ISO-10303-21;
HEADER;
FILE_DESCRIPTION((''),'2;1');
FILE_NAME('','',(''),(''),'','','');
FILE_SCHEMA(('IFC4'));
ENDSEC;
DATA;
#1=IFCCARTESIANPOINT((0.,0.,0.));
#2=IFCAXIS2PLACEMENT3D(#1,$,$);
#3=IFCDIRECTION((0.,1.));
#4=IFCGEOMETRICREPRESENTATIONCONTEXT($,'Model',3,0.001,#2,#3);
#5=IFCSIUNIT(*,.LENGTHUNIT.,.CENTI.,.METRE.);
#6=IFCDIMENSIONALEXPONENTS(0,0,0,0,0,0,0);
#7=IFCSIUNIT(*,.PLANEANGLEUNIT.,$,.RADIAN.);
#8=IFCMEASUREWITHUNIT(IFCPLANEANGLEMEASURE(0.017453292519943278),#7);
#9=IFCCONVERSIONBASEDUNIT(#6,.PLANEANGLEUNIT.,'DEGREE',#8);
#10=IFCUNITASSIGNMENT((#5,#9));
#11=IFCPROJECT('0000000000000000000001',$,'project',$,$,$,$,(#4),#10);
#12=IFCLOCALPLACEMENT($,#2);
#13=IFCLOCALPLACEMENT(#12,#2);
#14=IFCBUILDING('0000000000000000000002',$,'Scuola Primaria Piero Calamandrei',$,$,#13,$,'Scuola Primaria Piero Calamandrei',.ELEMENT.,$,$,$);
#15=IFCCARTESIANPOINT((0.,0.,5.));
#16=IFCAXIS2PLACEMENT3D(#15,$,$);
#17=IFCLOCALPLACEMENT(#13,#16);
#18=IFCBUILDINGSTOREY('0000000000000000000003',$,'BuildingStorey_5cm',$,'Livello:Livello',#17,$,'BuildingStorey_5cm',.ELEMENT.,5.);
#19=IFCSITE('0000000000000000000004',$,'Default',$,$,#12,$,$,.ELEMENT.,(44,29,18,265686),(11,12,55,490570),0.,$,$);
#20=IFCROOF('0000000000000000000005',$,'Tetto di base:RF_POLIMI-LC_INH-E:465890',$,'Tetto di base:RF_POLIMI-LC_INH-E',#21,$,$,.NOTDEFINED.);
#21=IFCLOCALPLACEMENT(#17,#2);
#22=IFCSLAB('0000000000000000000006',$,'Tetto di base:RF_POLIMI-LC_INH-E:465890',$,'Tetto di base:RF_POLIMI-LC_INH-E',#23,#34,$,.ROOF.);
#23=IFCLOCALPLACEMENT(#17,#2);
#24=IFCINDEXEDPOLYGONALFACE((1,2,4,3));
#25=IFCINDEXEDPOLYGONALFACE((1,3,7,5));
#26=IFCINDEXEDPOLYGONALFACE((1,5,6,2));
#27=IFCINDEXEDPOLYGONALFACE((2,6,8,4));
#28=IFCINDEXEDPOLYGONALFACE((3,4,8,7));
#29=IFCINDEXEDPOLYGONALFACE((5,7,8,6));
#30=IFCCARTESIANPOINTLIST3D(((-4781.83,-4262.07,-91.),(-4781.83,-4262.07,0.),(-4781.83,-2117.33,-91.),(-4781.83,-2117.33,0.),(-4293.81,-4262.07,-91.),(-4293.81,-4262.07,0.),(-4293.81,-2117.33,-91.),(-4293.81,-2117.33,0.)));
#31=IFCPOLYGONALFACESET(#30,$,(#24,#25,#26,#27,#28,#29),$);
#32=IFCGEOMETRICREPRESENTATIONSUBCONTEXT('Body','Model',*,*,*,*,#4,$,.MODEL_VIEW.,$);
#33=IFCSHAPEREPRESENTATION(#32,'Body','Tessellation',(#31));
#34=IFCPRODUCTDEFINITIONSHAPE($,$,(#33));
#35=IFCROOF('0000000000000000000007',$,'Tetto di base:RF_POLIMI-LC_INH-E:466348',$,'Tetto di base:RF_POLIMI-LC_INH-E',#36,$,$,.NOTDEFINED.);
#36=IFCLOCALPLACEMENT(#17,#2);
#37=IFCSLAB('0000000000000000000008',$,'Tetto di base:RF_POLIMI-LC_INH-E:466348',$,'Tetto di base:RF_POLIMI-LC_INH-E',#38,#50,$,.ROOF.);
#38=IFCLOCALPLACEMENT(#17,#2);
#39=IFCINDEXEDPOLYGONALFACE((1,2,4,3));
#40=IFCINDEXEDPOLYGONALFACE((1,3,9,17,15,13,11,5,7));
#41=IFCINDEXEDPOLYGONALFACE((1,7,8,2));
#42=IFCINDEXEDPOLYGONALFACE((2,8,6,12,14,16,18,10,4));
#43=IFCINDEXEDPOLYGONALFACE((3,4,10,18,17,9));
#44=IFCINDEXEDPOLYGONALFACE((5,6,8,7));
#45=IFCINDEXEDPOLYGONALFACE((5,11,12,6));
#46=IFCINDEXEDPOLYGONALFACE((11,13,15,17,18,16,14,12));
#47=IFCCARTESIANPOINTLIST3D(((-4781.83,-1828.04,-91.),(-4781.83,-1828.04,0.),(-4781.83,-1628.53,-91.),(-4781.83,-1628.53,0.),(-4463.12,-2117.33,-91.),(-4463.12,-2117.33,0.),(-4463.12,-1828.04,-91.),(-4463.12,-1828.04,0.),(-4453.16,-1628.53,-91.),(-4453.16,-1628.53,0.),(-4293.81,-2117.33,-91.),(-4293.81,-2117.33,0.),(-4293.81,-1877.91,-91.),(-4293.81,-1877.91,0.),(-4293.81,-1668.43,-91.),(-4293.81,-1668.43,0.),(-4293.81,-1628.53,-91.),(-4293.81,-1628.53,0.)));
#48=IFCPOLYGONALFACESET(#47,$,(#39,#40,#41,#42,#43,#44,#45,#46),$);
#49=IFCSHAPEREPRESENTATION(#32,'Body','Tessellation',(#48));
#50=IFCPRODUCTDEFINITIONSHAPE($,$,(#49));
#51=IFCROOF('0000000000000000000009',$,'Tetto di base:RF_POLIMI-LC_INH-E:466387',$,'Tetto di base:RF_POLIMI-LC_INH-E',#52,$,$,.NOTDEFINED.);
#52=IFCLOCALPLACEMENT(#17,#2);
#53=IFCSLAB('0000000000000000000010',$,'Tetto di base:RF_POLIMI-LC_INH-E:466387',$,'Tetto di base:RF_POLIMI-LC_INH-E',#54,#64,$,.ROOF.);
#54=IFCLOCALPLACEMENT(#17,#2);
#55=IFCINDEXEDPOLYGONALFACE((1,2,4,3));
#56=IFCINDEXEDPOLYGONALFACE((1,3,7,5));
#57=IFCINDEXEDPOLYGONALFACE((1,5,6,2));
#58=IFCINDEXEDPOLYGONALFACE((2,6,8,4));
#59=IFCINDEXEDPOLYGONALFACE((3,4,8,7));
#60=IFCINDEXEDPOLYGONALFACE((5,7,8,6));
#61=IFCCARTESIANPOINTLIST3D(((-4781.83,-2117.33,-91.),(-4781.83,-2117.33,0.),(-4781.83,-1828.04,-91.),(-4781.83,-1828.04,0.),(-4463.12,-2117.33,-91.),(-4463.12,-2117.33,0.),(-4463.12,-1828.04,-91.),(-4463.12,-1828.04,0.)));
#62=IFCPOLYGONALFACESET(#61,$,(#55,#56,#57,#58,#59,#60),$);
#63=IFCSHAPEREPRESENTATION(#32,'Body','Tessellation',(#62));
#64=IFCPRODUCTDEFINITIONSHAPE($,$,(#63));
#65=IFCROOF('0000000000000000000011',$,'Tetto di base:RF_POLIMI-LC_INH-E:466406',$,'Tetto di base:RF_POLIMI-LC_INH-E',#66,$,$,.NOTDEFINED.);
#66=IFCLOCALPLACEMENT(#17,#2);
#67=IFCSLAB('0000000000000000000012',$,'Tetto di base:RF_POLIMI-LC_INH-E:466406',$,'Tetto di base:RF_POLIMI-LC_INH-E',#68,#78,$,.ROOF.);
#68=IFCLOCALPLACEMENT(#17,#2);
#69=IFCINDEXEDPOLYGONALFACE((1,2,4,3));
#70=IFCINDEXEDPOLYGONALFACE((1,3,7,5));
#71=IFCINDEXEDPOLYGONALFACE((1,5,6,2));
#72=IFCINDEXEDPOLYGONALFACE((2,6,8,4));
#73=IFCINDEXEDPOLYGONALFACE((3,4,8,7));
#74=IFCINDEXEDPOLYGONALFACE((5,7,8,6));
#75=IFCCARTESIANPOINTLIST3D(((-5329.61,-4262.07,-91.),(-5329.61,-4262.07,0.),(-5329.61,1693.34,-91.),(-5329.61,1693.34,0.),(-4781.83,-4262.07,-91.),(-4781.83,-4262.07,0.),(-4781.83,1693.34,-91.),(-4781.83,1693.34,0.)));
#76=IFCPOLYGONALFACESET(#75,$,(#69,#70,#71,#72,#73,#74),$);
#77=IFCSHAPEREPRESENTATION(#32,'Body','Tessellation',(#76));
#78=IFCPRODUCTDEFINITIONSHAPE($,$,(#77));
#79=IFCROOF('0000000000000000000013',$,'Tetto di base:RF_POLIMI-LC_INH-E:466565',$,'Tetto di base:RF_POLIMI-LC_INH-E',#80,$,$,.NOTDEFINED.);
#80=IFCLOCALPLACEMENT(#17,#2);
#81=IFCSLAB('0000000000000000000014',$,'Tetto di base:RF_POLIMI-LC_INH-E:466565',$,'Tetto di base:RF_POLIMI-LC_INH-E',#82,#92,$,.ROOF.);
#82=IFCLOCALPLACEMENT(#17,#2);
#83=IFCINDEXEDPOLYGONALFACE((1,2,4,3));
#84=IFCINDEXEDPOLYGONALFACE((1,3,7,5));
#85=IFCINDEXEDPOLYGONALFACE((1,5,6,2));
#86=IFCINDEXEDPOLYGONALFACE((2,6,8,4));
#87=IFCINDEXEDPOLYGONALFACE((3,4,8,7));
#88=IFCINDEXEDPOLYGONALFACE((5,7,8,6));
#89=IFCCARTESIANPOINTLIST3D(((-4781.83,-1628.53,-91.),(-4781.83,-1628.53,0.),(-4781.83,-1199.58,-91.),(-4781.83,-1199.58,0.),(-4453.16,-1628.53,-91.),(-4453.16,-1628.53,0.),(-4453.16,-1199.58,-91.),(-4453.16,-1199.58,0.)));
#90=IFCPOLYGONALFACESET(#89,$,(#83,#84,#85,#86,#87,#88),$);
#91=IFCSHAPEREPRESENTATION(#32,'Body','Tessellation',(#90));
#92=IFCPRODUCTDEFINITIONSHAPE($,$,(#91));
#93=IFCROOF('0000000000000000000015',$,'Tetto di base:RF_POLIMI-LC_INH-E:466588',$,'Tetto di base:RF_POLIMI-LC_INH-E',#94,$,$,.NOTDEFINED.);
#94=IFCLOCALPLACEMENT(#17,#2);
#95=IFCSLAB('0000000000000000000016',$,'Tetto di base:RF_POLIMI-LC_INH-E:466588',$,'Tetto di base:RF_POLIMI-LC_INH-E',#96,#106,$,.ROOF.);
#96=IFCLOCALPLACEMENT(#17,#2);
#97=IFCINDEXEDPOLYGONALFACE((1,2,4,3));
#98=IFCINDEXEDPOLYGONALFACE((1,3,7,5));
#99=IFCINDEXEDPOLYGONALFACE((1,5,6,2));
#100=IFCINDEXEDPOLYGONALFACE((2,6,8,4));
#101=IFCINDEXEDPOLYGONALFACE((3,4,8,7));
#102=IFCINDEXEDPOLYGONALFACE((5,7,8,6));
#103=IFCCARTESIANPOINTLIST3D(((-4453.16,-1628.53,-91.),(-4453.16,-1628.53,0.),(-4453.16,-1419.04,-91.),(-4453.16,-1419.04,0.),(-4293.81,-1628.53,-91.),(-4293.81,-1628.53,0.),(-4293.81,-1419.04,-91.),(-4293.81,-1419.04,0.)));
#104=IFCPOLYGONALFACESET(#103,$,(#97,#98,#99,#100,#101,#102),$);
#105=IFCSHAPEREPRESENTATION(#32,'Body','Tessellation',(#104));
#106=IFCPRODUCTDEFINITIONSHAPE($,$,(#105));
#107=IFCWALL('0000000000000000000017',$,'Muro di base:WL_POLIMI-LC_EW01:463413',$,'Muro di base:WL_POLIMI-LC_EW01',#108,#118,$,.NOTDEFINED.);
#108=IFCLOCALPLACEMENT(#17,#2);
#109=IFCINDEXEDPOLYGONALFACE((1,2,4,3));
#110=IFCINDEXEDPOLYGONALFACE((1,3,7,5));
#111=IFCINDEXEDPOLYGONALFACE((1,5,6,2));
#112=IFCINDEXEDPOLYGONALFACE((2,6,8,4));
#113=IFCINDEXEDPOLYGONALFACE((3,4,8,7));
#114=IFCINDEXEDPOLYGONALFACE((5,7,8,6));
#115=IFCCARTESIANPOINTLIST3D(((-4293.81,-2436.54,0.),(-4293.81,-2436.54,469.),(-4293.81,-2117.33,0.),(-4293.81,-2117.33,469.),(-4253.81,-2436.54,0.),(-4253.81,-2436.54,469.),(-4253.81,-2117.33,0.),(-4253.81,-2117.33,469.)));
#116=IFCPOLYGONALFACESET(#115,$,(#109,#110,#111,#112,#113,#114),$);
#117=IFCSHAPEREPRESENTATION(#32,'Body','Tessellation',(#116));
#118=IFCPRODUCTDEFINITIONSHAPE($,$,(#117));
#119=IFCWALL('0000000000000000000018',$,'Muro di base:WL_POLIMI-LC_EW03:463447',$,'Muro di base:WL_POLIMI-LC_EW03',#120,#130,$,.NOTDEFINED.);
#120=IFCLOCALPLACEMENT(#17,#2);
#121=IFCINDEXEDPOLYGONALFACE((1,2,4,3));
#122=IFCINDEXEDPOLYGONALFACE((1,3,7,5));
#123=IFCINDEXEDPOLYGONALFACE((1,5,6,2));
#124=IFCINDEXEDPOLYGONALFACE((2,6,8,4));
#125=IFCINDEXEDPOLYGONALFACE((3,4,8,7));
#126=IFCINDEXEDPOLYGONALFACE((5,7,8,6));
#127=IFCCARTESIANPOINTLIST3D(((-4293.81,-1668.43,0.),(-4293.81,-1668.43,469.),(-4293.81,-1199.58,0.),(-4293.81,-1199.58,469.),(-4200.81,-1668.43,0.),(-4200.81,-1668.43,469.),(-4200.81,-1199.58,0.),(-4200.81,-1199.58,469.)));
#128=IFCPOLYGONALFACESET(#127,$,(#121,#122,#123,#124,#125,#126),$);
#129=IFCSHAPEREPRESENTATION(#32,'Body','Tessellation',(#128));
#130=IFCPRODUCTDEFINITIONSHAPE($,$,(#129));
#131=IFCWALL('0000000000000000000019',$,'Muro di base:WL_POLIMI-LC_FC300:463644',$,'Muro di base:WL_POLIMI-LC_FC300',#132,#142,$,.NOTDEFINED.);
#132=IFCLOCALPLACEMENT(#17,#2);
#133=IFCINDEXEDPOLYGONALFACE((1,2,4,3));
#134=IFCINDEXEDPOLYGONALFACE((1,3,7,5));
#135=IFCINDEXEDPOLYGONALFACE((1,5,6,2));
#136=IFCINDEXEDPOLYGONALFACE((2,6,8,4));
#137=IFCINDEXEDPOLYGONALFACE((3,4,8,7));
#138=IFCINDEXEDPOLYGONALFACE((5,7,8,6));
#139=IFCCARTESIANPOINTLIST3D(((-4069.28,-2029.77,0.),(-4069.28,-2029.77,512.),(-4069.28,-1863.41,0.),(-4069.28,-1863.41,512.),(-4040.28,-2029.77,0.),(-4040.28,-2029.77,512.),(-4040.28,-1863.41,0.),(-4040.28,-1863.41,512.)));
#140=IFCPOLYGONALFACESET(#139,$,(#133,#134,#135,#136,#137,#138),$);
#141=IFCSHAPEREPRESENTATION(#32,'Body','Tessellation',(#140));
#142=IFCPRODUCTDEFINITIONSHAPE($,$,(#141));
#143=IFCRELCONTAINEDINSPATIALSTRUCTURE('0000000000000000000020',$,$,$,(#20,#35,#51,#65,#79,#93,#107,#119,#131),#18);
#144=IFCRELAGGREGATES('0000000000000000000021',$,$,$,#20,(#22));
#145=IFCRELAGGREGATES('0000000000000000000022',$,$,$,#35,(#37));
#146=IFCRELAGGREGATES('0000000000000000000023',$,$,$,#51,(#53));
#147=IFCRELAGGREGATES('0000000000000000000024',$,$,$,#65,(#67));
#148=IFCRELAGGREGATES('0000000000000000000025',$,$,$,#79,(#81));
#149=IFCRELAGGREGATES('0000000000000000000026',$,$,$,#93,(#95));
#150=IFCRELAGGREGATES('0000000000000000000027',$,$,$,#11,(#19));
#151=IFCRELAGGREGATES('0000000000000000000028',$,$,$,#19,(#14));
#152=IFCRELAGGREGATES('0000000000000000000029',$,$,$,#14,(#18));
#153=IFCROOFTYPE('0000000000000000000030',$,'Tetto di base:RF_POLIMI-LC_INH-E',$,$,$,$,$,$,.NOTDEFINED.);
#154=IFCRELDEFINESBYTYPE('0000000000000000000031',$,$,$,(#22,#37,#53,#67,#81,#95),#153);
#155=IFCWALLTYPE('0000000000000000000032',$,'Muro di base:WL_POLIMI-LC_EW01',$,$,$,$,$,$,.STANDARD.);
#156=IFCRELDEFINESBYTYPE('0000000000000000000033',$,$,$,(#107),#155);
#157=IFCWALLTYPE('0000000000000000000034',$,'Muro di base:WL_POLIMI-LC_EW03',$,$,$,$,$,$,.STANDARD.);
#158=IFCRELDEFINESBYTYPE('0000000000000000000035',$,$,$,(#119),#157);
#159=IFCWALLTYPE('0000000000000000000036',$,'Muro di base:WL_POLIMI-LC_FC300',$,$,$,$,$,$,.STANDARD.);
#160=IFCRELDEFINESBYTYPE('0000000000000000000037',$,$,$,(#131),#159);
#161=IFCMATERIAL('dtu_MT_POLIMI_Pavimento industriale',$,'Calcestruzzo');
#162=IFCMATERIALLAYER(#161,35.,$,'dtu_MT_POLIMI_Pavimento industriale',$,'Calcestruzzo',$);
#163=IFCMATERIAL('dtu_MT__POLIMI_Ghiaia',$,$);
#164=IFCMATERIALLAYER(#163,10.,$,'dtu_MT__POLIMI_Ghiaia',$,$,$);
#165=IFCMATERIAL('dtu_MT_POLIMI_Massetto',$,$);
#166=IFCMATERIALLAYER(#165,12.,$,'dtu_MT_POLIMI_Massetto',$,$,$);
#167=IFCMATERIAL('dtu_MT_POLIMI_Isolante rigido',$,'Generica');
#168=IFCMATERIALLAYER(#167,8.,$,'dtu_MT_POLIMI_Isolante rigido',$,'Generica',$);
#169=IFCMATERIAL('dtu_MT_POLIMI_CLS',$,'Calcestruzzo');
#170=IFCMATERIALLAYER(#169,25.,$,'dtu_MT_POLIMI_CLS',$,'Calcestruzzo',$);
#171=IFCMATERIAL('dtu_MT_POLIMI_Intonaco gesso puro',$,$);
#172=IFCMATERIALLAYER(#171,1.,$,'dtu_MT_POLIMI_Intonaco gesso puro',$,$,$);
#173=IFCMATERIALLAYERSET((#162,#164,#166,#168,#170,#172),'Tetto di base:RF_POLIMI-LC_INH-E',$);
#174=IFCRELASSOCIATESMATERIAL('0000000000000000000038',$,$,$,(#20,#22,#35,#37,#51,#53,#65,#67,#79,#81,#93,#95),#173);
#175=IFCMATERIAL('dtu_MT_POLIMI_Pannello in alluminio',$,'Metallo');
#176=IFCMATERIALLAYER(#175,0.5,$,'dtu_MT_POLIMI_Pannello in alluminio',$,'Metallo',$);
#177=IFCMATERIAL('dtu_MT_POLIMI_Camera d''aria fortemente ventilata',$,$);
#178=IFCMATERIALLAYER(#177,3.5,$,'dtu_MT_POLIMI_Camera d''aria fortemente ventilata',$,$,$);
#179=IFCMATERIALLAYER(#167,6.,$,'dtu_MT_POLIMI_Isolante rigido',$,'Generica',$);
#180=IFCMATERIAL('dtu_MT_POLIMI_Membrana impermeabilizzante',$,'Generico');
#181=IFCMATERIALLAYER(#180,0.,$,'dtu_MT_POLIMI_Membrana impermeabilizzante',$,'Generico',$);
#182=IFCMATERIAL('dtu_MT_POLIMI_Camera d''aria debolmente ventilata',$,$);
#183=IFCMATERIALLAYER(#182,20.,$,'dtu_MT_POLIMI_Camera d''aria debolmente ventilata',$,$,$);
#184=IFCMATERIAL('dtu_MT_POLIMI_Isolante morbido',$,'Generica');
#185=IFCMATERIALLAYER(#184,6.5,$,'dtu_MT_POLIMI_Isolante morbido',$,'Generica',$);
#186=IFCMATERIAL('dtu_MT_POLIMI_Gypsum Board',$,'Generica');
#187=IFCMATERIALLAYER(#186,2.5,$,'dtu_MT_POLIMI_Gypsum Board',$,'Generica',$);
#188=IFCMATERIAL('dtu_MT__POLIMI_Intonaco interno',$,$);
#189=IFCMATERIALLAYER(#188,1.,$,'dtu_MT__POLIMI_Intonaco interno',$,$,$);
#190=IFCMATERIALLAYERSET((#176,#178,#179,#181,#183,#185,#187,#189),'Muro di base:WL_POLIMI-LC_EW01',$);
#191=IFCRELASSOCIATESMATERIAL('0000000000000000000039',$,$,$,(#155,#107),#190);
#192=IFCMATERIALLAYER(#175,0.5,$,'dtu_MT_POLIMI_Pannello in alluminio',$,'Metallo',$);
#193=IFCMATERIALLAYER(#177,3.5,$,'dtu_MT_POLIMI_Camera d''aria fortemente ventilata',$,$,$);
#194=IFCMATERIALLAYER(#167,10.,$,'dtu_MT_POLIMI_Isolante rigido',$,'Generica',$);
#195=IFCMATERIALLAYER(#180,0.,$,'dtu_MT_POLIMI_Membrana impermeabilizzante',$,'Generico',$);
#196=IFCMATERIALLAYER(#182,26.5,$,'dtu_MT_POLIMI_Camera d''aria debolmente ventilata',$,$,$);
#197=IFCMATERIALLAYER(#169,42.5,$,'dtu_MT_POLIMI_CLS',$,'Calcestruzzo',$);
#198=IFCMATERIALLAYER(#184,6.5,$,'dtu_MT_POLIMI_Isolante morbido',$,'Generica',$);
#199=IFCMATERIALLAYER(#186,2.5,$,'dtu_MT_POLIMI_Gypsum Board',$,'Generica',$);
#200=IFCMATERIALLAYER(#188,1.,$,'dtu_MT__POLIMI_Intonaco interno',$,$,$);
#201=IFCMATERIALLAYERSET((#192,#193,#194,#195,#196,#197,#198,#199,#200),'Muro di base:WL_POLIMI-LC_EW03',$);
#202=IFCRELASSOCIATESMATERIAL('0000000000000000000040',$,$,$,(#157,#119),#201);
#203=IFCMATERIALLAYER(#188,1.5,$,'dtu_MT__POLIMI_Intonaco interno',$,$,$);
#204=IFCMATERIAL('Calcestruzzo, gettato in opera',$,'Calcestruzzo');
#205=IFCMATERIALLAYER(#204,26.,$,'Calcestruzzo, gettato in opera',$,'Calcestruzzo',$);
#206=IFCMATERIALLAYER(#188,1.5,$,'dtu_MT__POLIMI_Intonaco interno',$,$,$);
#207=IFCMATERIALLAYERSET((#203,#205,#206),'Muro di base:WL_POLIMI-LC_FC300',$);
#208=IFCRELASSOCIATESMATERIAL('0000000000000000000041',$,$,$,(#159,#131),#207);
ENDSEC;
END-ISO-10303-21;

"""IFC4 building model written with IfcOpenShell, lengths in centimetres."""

from ifc_helpers import new_model, entity, si_unit, converted_unit, direction, frame, frame_2d, origin, place, context, subcontext, project, spatial, polyline, rectangle, outline, extrude, clip, bounded_halfspace, material, layer, layer_set, layer_usage, type_object, element, aggregate, save


model = new_model("IFC4")

# Units and contexts
model_context = context("Model", 3, precision=0.001, world=origin(), true_north=direction((0.0, 1.0)))
body_context = subcontext(model_context, "Body", "Model", "MODEL_VIEW")
ifc_project = project(units=[si_unit("LENGTHUNIT", "METRE", prefix="CENTI"), converted_unit("PLANEANGLEUNIT", "DEGREE", entity("IfcPlaneAngleMeasure", 0.017453292519943278), si_unit("PLANEANGLEUNIT", "RADIAN"), dimensions=[0, 0, 0, 0, 0, 0, 0])], contexts=[model_context])

# Site, building, storey
site_placement = place(None, origin())
site = spatial("IfcSite", under=ifc_project, at=site_placement, Name="Default", CompositionType="ELEMENT", RefLatitude=(44, 29, 18, 265686), RefLongitude=(11, 12, 55, 490570), RefElevation=0.0)
building_placement = place(site_placement, origin())
building = spatial("IfcBuilding", under=site, at=building_placement, Name="Scuola Primaria Piero Calamandrei", LongName="Scuola Primaria Piero Calamandrei", CompositionType="ELEMENT")
storey_placement = place(building_placement, frame((0.0, 0.0, 5.0)))
storey = spatial("IfcBuildingStorey", under=building, at=storey_placement, Name="BuildingStorey_5cm", ObjectType="Livello:Livello", LongName="BuildingStorey_5cm", CompositionType="ELEMENT", Elevation=5.0)

# Roofs, slabs
ifc_material_1 = material(Name="dtu_MT_POLIMI_Pavimento industriale", Category="Calcestruzzo")
ifc_layer_1 = layer(ifc_material_1, 35.0, Name="dtu_MT_POLIMI_Pavimento industriale", Category="Calcestruzzo")
ifc_material_2 = material(Name="dtu_MT__POLIMI_Ghiaia")
ifc_layer_2 = layer(ifc_material_2, 10.0, Name="dtu_MT__POLIMI_Ghiaia")
ifc_material_3 = material(Name="dtu_MT_POLIMI_Massetto")
ifc_layer_3 = layer(ifc_material_3, 12.0, Name="dtu_MT_POLIMI_Massetto")
ifc_material_4 = material(Name="dtu_MT_POLIMI_Isolante rigido", Category="Generica")
ifc_layer_4 = layer(ifc_material_4, 8.0, Name="dtu_MT_POLIMI_Isolante rigido", Category="Generica")
ifc_material_5 = material(Name="dtu_MT_POLIMI_CLS", Category="Calcestruzzo")
ifc_layer_5 = layer(ifc_material_5, 25.0, Name="dtu_MT_POLIMI_CLS", Category="Calcestruzzo")
ifc_material_6 = material(Name="dtu_MT_POLIMI_Intonaco gesso puro")
ifc_layer_6 = layer(ifc_material_6, 1.0, Name="dtu_MT_POLIMI_Intonaco gesso puro")
ifc_layer_set_1 = layer_set([ifc_layer_1, ifc_layer_2, ifc_layer_3, ifc_layer_4, ifc_layer_5, ifc_layer_6], Name="Tetto di base:RF_POLIMI-LC_INH-E")
roof_1_placement = place(storey_placement, frame((-4781.83, -4262.07, -91.0)))
roof_1 = element("IfcRoof", 1, at=roof_1_placement, inside=storey, material=ifc_layer_set_1, Name="Tetto di base:RF_POLIMI-LC_INH-E:465890", ObjectType="Tetto di base:RF_POLIMI-LC_INH-E", PredefinedType="NOTDEFINED")
roof_type = type_object("IfcRoofType", Name="Tetto di base:RF_POLIMI-LC_INH-E", PredefinedType="NOTDEFINED")
slab_1_placement = place(roof_1_placement, origin())
slab_1 = element("IfcSlab", 2, at=slab_1_placement, type_object=roof_type, material=ifc_layer_set_1, Name="Tetto di base:RF_POLIMI-LC_INH-E:465890", ObjectType="Tetto di base:RF_POLIMI-LC_INH-E", PredefinedType="ROOF", context=body_context, shape_type="SweptSolid", body=[
    extrude(rectangle(XDim=488.02, YDim=2144.74, at=frame_2d((0.0, 0.0), x_axis=(1.0, 0.0))), frame((244.01, 1072.37, 0.0)), (0.0, 0.0, 1.0), 91.0),
])
aggregate(roof_1, [slab_1])
roof_2_placement = place(storey_placement, frame((-4781.83, -2117.33, -91.0)))
roof_2 = element("IfcRoof", 3, at=roof_2_placement, inside=storey, material=ifc_layer_set_1, Name="Tetto di base:RF_POLIMI-LC_INH-E:466348", ObjectType="Tetto di base:RF_POLIMI-LC_INH-E", PredefinedType="NOTDEFINED")
slab_2_placement = place(roof_2_placement, origin())
slab_2 = element("IfcSlab", 4, at=slab_2_placement, type_object=roof_type, material=ifc_layer_set_1, Name="Tetto di base:RF_POLIMI-LC_INH-E:466348", ObjectType="Tetto di base:RF_POLIMI-LC_INH-E", PredefinedType="ROOF", context=body_context, shape_type="SweptSolid", body=[
    extrude(outline(polyline([(244.01, 244.4), (84.66, 244.4), (-244.01, 244.4), (-244.01, 44.89), (74.7, 44.89), (74.7, -244.4), (244.01, -244.4), (244.01, -4.99), (244.01, 204.5), (244.01, 244.4)])), frame((244.01, 244.4, 0.0)), (0.0, 0.0, 1.0), 91.0),
])
aggregate(roof_2, [slab_2])
roof_3_placement = place(storey_placement, frame((-4781.83, -2117.33, -91.0)))
roof_3 = element("IfcRoof", 5, at=roof_3_placement, inside=storey, material=ifc_layer_set_1, Name="Tetto di base:RF_POLIMI-LC_INH-E:466387", ObjectType="Tetto di base:RF_POLIMI-LC_INH-E", PredefinedType="NOTDEFINED")
slab_3_placement = place(roof_3_placement, origin())
slab_3 = element("IfcSlab", 6, at=slab_3_placement, type_object=roof_type, material=ifc_layer_set_1, Name="Tetto di base:RF_POLIMI-LC_INH-E:466387", ObjectType="Tetto di base:RF_POLIMI-LC_INH-E", PredefinedType="ROOF", context=body_context, shape_type="SweptSolid", body=[
    extrude(rectangle(XDim=289.29, YDim=318.71, at=frame_2d((0.0, 0.0), x_axis=(0.0, -1.0))), frame((159.35, 144.65, 0.0)), (0.0, 0.0, 1.0), 91.0),
])
aggregate(roof_3, [slab_3])
roof_4_placement = place(storey_placement, frame((-5329.61, -4262.07, -91.0)))
roof_4 = element("IfcRoof", 7, at=roof_4_placement, inside=storey, material=ifc_layer_set_1, Name="Tetto di base:RF_POLIMI-LC_INH-E:466406", ObjectType="Tetto di base:RF_POLIMI-LC_INH-E", PredefinedType="NOTDEFINED")
slab_4_placement = place(roof_4_placement, origin())
slab_4 = element("IfcSlab", 8, at=slab_4_placement, type_object=roof_type, material=ifc_layer_set_1, Name="Tetto di base:RF_POLIMI-LC_INH-E:466406", ObjectType="Tetto di base:RF_POLIMI-LC_INH-E", PredefinedType="ROOF", context=body_context, shape_type="SweptSolid", body=[
    extrude(rectangle(XDim=5955.41, YDim=547.78, at=frame_2d((0.0, 0.0), x_axis=(0.0, -1.0))), frame((273.89, 2977.7, 0.0)), (0.0, 0.0, 1.0), 91.0),
])
aggregate(roof_4, [slab_4])
roof_5_placement = place(storey_placement, frame((-4781.83, -1628.53, -91.0)))
roof_5 = element("IfcRoof", 9, at=roof_5_placement, inside=storey, material=ifc_layer_set_1, Name="Tetto di base:RF_POLIMI-LC_INH-E:466565", ObjectType="Tetto di base:RF_POLIMI-LC_INH-E", PredefinedType="NOTDEFINED")
slab_5_placement = place(roof_5_placement, origin())
slab_5 = element("IfcSlab", 10, at=slab_5_placement, type_object=roof_type, material=ifc_layer_set_1, Name="Tetto di base:RF_POLIMI-LC_INH-E:466565", ObjectType="Tetto di base:RF_POLIMI-LC_INH-E", PredefinedType="ROOF", context=body_context, shape_type="SweptSolid", body=[
    extrude(rectangle(XDim=428.95, YDim=328.67, at=frame_2d((0.0, 0.0), x_axis=(0.0, -1.0))), frame((164.33, 214.47, 0.0)), (0.0, 0.0, 1.0), 91.0),
])
aggregate(roof_5, [slab_5])
roof_6_placement = place(storey_placement, frame((-4453.16, -1628.53, -91.0)))
roof_6 = element("IfcRoof", 11, at=roof_6_placement, inside=storey, material=ifc_layer_set_1, Name="Tetto di base:RF_POLIMI-LC_INH-E:466588", ObjectType="Tetto di base:RF_POLIMI-LC_INH-E", PredefinedType="NOTDEFINED")
slab_6_placement = place(roof_6_placement, origin())
slab_6 = element("IfcSlab", 12, at=slab_6_placement, type_object=roof_type, material=ifc_layer_set_1, Name="Tetto di base:RF_POLIMI-LC_INH-E:466588", ObjectType="Tetto di base:RF_POLIMI-LC_INH-E", PredefinedType="ROOF", context=body_context, shape_type="SweptSolid", body=[
    extrude(rectangle(XDim=159.35, YDim=209.49, at=frame_2d((0.0, 0.0), x_axis=(1.0, 0.0))), frame((79.68, 104.74, 0.0)), (0.0, 0.0, 1.0), 91.0),
])
aggregate(roof_6, [slab_6])

# Walls
ifc_material_7 = material(Name="dtu_MT_POLIMI_Pannello in alluminio", Category="Metallo")
ifc_layer_7 = layer(ifc_material_7, 0.5, Name="dtu_MT_POLIMI_Pannello in alluminio", Category="Metallo")
ifc_material_8 = material(Name="dtu_MT_POLIMI_Camera d'aria fortemente ventilata")
ifc_layer_8 = layer(ifc_material_8, 3.5, Name="dtu_MT_POLIMI_Camera d'aria fortemente ventilata")
ifc_layer_9 = layer(ifc_material_4, 6.0, Name="dtu_MT_POLIMI_Isolante rigido", Category="Generica")
ifc_material_9 = material(Name="dtu_MT_POLIMI_Membrana impermeabilizzante", Category="Generico")
ifc_layer_10 = layer(ifc_material_9, 0.0, Name="dtu_MT_POLIMI_Membrana impermeabilizzante", Category="Generico")
ifc_material_10 = material(Name="dtu_MT_POLIMI_Camera d'aria debolmente ventilata")
ifc_layer_11 = layer(ifc_material_10, 20.0, Name="dtu_MT_POLIMI_Camera d'aria debolmente ventilata")
ifc_material_11 = material(Name="dtu_MT_POLIMI_Isolante morbido", Category="Generica")
ifc_layer_12 = layer(ifc_material_11, 6.5, Name="dtu_MT_POLIMI_Isolante morbido", Category="Generica")
ifc_material_12 = material(Name="dtu_MT_POLIMI_Gypsum Board", Category="Generica")
ifc_layer_13 = layer(ifc_material_12, 2.5, Name="dtu_MT_POLIMI_Gypsum Board", Category="Generica")
ifc_material_13 = material(Name="dtu_MT__POLIMI_Intonaco interno")
ifc_layer_14 = layer(ifc_material_13, 1.0, Name="dtu_MT__POLIMI_Intonaco interno")
ifc_layer_set_2 = layer_set([ifc_layer_7, ifc_layer_8, ifc_layer_9, ifc_layer_10, ifc_layer_11, ifc_layer_12, ifc_layer_13, ifc_layer_14], Name="Muro di base:WL_POLIMI-LC_EW01")
ifc_layer_usage_1 = layer_usage(ifc_layer_set_2, "AXIS2", "NEGATIVE", 20.0)
wall_type_1 = type_object("IfcWallType", Name="Muro di base:WL_POLIMI-LC_EW01", PredefinedType="STANDARD", material=ifc_layer_set_2)
wall_1_placement = place(storey_placement, frame((-4273.81, -2436.54, 0.0), z_axis=(0.0, 0.0, 1.0), x_axis=(0.0, 1.0, 0.0)))
element("IfcWall", 13, at=wall_1_placement, inside=storey, type_object=wall_type_1, material=ifc_layer_usage_1, Name="Muro di base:WL_POLIMI-LC_EW01:463413", ObjectType="Muro di base:WL_POLIMI-LC_EW01", PredefinedType="NOTDEFINED", context=body_context, shape_type="Clipping", body=[
    clip(extrude(rectangle(XDim=319.22, YDim=40.0, at=frame_2d((159.61, 0.0), x_axis=(-1.0, 0.0))), origin(), (0.0, 0.0, 1.0), 469.0), bounded_halfspace(frame((0.0, -20.0, 469.0), z_axis=(0.0, 0.0, -1.0), x_axis=(0.0, -1.0, 0.0)), True, frame((0.0, -20.0, 469.0)), polyline([(0.0, 0.0), (10.75, 0.0), (319.22, 0.0), (319.22, 40.0), (0.0, 40.0), (0.0, 35.0), (0.0, 0.0)]))),
])
ifc_layer_15 = layer(ifc_material_7, 0.5, Name="dtu_MT_POLIMI_Pannello in alluminio", Category="Metallo")
ifc_layer_16 = layer(ifc_material_8, 3.5, Name="dtu_MT_POLIMI_Camera d'aria fortemente ventilata")
ifc_layer_17 = layer(ifc_material_4, 10.0, Name="dtu_MT_POLIMI_Isolante rigido", Category="Generica")
ifc_layer_18 = layer(ifc_material_9, 0.0, Name="dtu_MT_POLIMI_Membrana impermeabilizzante", Category="Generico")
ifc_layer_19 = layer(ifc_material_10, 26.5, Name="dtu_MT_POLIMI_Camera d'aria debolmente ventilata")
ifc_layer_20 = layer(ifc_material_5, 42.5, Name="dtu_MT_POLIMI_CLS", Category="Calcestruzzo")
ifc_layer_21 = layer(ifc_material_11, 6.5, Name="dtu_MT_POLIMI_Isolante morbido", Category="Generica")
ifc_layer_22 = layer(ifc_material_12, 2.5, Name="dtu_MT_POLIMI_Gypsum Board", Category="Generica")
ifc_layer_23 = layer(ifc_material_13, 1.0, Name="dtu_MT__POLIMI_Intonaco interno")
ifc_layer_set_3 = layer_set([ifc_layer_15, ifc_layer_16, ifc_layer_17, ifc_layer_18, ifc_layer_19, ifc_layer_20, ifc_layer_21, ifc_layer_22, ifc_layer_23], Name="Muro di base:WL_POLIMI-LC_EW03")
ifc_layer_usage_2 = layer_usage(ifc_layer_set_3, "AXIS2", "NEGATIVE", 46.5)
wall_type_2 = type_object("IfcWallType", Name="Muro di base:WL_POLIMI-LC_EW03", PredefinedType="STANDARD", material=ifc_layer_set_3)
wall_2_placement = place(storey_placement, frame((-4247.31, -1668.43, 0.0), z_axis=(0.0, 0.0, 1.0), x_axis=(0.0, 1.0, 0.0)))
element("IfcWall", 14, at=wall_2_placement, inside=storey, type_object=wall_type_2, material=ifc_layer_usage_2, Name="Muro di base:WL_POLIMI-LC_EW03:463447", ObjectType="Muro di base:WL_POLIMI-LC_EW03", PredefinedType="NOTDEFINED", context=body_context, shape_type="Clipping", body=[
    clip(extrude(rectangle(XDim=468.85, YDim=93.0, at=frame_2d((234.43, 0.0), x_axis=(-1.0, 0.0))), origin(), (0.0, 0.0, 1.0), 469.0), bounded_halfspace(frame((0.0, -46.5, 469.0), z_axis=(0.0, 0.0, -1.0), x_axis=(0.0, 1.0, 0.0)), True, frame((0.0, -46.5, 469.0)), polyline([(0.0, 0.0), (447.1, 0.0), (468.85, 0.0), (468.85, 93.0), (447.1, 93.0), (0.0, 93.0), (0.0, 0.0)]))),
])
ifc_layer_24 = layer(ifc_material_13, 1.5, Name="dtu_MT__POLIMI_Intonaco interno")
ifc_material_14 = material(Name="Calcestruzzo, gettato in opera", Category="Calcestruzzo")
ifc_layer_25 = layer(ifc_material_14, 26.0, Name="Calcestruzzo, gettato in opera", Category="Calcestruzzo")
ifc_layer_26 = layer(ifc_material_13, 1.5, Name="dtu_MT__POLIMI_Intonaco interno")
ifc_layer_set_4 = layer_set([ifc_layer_24, ifc_layer_25, ifc_layer_26], Name="Muro di base:WL_POLIMI-LC_FC300")
wall_type_3 = type_object("IfcWallType", Name="Muro di base:WL_POLIMI-LC_FC300", PredefinedType="STANDARD", material=ifc_layer_set_4)
ifc_layer_usage_3 = layer_usage(ifc_layer_set_4, "AXIS2", "NEGATIVE", 14.5)
wall_3_placement = place(storey_placement, frame((-4054.78, -1863.41, 0.0), z_axis=(0.0, 0.0, 1.0), x_axis=(0.0, -1.0, 0.0)))
element("IfcWall", 15, at=wall_3_placement, inside=storey, type_object=wall_type_3, material=ifc_layer_usage_3, Name="Muro di base:WL_POLIMI-LC_FC300:463644", ObjectType="Muro di base:WL_POLIMI-LC_FC300", PredefinedType="NOTDEFINED", context=body_context, shape_type="SweptSolid", body=[
    extrude(rectangle(XDim=166.36, YDim=29.0, at=frame_2d((83.18, 0.0), x_axis=(-1.0, 0.0))), origin(), (0.0, 0.0, 1.0), 512.0),
])

save(model, "model.ifc")
